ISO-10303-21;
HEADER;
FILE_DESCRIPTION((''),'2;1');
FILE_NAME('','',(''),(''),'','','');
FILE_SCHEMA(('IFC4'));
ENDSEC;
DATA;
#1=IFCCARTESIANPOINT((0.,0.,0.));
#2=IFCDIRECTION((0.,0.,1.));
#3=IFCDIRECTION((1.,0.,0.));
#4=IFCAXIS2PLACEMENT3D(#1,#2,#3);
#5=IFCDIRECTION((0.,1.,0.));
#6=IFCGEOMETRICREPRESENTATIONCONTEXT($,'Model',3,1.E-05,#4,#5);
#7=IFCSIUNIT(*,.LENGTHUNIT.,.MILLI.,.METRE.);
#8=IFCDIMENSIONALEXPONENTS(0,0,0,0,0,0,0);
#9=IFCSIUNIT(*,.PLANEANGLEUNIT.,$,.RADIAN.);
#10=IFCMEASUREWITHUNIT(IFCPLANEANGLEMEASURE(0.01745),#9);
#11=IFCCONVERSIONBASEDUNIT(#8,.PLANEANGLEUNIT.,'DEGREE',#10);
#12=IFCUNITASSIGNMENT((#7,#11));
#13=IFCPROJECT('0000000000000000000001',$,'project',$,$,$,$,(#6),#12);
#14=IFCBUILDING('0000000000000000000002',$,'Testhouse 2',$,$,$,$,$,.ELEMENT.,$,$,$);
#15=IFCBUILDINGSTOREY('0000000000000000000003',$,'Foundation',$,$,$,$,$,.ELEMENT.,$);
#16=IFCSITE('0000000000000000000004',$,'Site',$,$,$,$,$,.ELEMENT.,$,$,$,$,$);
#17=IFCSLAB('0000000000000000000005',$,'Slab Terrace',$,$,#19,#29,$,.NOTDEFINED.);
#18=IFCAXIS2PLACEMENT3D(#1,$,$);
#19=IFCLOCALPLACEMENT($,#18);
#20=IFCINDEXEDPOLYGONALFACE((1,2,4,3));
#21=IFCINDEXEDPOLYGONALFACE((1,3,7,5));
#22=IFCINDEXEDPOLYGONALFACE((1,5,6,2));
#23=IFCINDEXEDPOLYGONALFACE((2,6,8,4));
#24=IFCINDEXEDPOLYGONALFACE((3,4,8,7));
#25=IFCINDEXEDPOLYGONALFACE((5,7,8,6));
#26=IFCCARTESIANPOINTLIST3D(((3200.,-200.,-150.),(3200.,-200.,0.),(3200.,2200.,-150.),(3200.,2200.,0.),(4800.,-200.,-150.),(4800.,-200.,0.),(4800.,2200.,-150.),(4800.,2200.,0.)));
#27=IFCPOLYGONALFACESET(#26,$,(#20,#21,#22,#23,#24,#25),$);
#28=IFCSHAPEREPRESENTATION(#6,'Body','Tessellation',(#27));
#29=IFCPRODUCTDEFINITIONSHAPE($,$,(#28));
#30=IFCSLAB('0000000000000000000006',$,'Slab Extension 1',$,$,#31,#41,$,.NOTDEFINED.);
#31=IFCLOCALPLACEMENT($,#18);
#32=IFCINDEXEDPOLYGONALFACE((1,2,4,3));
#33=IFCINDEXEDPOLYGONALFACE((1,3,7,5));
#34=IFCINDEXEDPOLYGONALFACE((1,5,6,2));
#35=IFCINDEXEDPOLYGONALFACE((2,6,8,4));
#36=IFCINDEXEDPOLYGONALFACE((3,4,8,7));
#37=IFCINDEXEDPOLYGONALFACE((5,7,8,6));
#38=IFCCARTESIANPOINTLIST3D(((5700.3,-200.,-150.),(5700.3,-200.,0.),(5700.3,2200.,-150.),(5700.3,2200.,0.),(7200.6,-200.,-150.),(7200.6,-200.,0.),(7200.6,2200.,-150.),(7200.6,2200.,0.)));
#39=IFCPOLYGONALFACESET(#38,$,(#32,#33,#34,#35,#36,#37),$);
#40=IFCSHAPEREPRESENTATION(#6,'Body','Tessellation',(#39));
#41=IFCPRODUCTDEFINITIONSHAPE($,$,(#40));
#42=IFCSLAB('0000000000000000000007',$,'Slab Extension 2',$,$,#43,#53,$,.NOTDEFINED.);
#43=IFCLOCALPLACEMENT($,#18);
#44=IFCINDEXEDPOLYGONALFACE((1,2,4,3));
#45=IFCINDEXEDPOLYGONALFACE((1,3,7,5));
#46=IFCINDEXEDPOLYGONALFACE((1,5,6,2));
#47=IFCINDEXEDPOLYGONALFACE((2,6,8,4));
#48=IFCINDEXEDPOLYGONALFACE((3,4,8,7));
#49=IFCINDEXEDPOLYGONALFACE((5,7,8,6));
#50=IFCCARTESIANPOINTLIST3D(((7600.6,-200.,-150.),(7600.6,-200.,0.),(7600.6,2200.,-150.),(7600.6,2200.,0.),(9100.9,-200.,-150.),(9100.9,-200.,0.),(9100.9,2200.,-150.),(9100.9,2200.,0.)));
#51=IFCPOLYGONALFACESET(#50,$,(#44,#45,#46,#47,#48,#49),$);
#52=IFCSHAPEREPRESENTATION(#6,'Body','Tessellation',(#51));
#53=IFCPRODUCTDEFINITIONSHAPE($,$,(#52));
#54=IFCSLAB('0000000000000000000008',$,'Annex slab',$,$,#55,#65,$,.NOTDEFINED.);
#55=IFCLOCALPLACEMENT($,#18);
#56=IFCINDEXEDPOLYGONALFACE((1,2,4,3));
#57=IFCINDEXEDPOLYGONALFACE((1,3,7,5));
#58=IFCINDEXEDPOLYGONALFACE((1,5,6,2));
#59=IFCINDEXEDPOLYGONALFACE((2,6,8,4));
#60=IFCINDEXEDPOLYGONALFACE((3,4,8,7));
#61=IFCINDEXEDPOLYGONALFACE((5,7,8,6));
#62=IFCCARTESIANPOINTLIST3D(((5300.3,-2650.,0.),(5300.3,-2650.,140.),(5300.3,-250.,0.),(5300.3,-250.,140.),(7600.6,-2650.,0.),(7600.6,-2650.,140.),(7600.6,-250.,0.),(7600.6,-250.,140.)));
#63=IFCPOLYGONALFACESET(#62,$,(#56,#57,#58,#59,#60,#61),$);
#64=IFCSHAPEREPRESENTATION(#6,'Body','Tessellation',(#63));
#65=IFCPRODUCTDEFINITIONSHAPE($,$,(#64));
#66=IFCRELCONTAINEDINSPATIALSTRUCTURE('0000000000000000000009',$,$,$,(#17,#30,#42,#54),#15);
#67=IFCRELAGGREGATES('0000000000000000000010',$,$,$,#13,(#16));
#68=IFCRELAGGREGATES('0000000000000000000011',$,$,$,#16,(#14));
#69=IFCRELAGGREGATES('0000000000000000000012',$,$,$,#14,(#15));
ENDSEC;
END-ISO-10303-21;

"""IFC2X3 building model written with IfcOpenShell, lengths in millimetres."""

from ifc_helpers import new_model, entity, si_unit, converted_unit, direction, frame, origin_with_axes, place, context, project, spatial, polyline, outline, extrude, element, save


model = new_model("IFC2X3")

# Units and contexts
model_context = context("Model", 3, precision=1e-05, world=origin_with_axes(), true_north=direction((0.0, 1.0, 0.0)))
ifc_project = project(units=[si_unit("LENGTHUNIT", "METRE", prefix="MILLI"), converted_unit("PLANEANGLEUNIT", "DEGREE", entity("IfcPlaneAngleMeasure", 0.01745), si_unit("PLANEANGLEUNIT", "RADIAN"), dimensions=[0, 0, 0, 0, 0, 0, 0])], contexts=[model_context])

# Site, building, storey
site = spatial("IfcSite", under=ifc_project, Name="Site", CompositionType="ELEMENT")
building = spatial("IfcBuilding", under=site, Name="Testhouse 2", CompositionType="ELEMENT")
storey = spatial("IfcBuildingStorey", under=building, Name="Foundation", CompositionType="ELEMENT")

# Slabs
slab_1_placement = place(None, origin_with_axes())
element("IfcSlab", 1, at=slab_1_placement, inside=storey, Name="Slab Terrace", PredefinedType="NOTDEFINED", context=model_context, shape_type="SweptSolid", body=[
    extrude(outline(polyline([(0.0, 0.0), (-1600.0, 0.0), (-1600.0, 2400.0), (0.0, 2400.0), (0.0, 0.0)])), frame((4800.0, -200.0, -150.0), z_axis=(0.0, 0.0, 1.0), x_axis=(1.0, 0.0, 0.0)), (0.0, 0.0, 1.0), 150.0),
])
slab_2_placement = place(None, origin_with_axes())
element("IfcSlab", 2, at=slab_2_placement, inside=storey, Name="Slab Extension 1", PredefinedType="NOTDEFINED", context=model_context, shape_type="SweptSolid", body=[
    extrude(outline(polyline([(0.0, 0.0), (1500.3, 0.0), (1500.3, -2400.0), (0.0, -2400.0), (0.0, 0.0)])), frame((5700.3, 2200.0, -150.0), z_axis=(0.0, 0.0, 1.0), x_axis=(1.0, 0.0, 0.0)), (0.0, 0.0, 1.0), 150.0),
])
slab_3_placement = place(None, origin_with_axes())
element("IfcSlab", 3, at=slab_3_placement, inside=storey, Name="Slab Extension 2", PredefinedType="NOTDEFINED", context=model_context, shape_type="SweptSolid", body=[
    extrude(outline(polyline([(0.0, 0.0), (1500.3, 0.0), (1500.3, -2400.0), (0.0, -2400.0), (0.0, 0.0)])), frame((7600.6, 2200.0, -150.0), z_axis=(0.0, 0.0, 1.0), x_axis=(1.0, 0.0, 0.0)), (0.0, 0.0, 1.0), 150.0),
])
slab_4_placement = place(None, origin_with_axes())
element("IfcSlab", 4, at=slab_4_placement, inside=storey, Name="Annex slab", PredefinedType="NOTDEFINED", context=model_context, shape_type="SweptSolid", body=[
    extrude(outline(polyline([(0.0, 0.0), (2300.3, 0.0), (2300.3, -2400.0), (0.0, -2400.0), (0.0, 0.0)])), frame((5300.3, -250.0, 0.0), z_axis=(0.0, 0.0, 1.0), x_axis=(1.0, 0.0, 0.0)), (0.0, 0.0, 1.0), 140.0),
])

save(model, "model.ifc")
